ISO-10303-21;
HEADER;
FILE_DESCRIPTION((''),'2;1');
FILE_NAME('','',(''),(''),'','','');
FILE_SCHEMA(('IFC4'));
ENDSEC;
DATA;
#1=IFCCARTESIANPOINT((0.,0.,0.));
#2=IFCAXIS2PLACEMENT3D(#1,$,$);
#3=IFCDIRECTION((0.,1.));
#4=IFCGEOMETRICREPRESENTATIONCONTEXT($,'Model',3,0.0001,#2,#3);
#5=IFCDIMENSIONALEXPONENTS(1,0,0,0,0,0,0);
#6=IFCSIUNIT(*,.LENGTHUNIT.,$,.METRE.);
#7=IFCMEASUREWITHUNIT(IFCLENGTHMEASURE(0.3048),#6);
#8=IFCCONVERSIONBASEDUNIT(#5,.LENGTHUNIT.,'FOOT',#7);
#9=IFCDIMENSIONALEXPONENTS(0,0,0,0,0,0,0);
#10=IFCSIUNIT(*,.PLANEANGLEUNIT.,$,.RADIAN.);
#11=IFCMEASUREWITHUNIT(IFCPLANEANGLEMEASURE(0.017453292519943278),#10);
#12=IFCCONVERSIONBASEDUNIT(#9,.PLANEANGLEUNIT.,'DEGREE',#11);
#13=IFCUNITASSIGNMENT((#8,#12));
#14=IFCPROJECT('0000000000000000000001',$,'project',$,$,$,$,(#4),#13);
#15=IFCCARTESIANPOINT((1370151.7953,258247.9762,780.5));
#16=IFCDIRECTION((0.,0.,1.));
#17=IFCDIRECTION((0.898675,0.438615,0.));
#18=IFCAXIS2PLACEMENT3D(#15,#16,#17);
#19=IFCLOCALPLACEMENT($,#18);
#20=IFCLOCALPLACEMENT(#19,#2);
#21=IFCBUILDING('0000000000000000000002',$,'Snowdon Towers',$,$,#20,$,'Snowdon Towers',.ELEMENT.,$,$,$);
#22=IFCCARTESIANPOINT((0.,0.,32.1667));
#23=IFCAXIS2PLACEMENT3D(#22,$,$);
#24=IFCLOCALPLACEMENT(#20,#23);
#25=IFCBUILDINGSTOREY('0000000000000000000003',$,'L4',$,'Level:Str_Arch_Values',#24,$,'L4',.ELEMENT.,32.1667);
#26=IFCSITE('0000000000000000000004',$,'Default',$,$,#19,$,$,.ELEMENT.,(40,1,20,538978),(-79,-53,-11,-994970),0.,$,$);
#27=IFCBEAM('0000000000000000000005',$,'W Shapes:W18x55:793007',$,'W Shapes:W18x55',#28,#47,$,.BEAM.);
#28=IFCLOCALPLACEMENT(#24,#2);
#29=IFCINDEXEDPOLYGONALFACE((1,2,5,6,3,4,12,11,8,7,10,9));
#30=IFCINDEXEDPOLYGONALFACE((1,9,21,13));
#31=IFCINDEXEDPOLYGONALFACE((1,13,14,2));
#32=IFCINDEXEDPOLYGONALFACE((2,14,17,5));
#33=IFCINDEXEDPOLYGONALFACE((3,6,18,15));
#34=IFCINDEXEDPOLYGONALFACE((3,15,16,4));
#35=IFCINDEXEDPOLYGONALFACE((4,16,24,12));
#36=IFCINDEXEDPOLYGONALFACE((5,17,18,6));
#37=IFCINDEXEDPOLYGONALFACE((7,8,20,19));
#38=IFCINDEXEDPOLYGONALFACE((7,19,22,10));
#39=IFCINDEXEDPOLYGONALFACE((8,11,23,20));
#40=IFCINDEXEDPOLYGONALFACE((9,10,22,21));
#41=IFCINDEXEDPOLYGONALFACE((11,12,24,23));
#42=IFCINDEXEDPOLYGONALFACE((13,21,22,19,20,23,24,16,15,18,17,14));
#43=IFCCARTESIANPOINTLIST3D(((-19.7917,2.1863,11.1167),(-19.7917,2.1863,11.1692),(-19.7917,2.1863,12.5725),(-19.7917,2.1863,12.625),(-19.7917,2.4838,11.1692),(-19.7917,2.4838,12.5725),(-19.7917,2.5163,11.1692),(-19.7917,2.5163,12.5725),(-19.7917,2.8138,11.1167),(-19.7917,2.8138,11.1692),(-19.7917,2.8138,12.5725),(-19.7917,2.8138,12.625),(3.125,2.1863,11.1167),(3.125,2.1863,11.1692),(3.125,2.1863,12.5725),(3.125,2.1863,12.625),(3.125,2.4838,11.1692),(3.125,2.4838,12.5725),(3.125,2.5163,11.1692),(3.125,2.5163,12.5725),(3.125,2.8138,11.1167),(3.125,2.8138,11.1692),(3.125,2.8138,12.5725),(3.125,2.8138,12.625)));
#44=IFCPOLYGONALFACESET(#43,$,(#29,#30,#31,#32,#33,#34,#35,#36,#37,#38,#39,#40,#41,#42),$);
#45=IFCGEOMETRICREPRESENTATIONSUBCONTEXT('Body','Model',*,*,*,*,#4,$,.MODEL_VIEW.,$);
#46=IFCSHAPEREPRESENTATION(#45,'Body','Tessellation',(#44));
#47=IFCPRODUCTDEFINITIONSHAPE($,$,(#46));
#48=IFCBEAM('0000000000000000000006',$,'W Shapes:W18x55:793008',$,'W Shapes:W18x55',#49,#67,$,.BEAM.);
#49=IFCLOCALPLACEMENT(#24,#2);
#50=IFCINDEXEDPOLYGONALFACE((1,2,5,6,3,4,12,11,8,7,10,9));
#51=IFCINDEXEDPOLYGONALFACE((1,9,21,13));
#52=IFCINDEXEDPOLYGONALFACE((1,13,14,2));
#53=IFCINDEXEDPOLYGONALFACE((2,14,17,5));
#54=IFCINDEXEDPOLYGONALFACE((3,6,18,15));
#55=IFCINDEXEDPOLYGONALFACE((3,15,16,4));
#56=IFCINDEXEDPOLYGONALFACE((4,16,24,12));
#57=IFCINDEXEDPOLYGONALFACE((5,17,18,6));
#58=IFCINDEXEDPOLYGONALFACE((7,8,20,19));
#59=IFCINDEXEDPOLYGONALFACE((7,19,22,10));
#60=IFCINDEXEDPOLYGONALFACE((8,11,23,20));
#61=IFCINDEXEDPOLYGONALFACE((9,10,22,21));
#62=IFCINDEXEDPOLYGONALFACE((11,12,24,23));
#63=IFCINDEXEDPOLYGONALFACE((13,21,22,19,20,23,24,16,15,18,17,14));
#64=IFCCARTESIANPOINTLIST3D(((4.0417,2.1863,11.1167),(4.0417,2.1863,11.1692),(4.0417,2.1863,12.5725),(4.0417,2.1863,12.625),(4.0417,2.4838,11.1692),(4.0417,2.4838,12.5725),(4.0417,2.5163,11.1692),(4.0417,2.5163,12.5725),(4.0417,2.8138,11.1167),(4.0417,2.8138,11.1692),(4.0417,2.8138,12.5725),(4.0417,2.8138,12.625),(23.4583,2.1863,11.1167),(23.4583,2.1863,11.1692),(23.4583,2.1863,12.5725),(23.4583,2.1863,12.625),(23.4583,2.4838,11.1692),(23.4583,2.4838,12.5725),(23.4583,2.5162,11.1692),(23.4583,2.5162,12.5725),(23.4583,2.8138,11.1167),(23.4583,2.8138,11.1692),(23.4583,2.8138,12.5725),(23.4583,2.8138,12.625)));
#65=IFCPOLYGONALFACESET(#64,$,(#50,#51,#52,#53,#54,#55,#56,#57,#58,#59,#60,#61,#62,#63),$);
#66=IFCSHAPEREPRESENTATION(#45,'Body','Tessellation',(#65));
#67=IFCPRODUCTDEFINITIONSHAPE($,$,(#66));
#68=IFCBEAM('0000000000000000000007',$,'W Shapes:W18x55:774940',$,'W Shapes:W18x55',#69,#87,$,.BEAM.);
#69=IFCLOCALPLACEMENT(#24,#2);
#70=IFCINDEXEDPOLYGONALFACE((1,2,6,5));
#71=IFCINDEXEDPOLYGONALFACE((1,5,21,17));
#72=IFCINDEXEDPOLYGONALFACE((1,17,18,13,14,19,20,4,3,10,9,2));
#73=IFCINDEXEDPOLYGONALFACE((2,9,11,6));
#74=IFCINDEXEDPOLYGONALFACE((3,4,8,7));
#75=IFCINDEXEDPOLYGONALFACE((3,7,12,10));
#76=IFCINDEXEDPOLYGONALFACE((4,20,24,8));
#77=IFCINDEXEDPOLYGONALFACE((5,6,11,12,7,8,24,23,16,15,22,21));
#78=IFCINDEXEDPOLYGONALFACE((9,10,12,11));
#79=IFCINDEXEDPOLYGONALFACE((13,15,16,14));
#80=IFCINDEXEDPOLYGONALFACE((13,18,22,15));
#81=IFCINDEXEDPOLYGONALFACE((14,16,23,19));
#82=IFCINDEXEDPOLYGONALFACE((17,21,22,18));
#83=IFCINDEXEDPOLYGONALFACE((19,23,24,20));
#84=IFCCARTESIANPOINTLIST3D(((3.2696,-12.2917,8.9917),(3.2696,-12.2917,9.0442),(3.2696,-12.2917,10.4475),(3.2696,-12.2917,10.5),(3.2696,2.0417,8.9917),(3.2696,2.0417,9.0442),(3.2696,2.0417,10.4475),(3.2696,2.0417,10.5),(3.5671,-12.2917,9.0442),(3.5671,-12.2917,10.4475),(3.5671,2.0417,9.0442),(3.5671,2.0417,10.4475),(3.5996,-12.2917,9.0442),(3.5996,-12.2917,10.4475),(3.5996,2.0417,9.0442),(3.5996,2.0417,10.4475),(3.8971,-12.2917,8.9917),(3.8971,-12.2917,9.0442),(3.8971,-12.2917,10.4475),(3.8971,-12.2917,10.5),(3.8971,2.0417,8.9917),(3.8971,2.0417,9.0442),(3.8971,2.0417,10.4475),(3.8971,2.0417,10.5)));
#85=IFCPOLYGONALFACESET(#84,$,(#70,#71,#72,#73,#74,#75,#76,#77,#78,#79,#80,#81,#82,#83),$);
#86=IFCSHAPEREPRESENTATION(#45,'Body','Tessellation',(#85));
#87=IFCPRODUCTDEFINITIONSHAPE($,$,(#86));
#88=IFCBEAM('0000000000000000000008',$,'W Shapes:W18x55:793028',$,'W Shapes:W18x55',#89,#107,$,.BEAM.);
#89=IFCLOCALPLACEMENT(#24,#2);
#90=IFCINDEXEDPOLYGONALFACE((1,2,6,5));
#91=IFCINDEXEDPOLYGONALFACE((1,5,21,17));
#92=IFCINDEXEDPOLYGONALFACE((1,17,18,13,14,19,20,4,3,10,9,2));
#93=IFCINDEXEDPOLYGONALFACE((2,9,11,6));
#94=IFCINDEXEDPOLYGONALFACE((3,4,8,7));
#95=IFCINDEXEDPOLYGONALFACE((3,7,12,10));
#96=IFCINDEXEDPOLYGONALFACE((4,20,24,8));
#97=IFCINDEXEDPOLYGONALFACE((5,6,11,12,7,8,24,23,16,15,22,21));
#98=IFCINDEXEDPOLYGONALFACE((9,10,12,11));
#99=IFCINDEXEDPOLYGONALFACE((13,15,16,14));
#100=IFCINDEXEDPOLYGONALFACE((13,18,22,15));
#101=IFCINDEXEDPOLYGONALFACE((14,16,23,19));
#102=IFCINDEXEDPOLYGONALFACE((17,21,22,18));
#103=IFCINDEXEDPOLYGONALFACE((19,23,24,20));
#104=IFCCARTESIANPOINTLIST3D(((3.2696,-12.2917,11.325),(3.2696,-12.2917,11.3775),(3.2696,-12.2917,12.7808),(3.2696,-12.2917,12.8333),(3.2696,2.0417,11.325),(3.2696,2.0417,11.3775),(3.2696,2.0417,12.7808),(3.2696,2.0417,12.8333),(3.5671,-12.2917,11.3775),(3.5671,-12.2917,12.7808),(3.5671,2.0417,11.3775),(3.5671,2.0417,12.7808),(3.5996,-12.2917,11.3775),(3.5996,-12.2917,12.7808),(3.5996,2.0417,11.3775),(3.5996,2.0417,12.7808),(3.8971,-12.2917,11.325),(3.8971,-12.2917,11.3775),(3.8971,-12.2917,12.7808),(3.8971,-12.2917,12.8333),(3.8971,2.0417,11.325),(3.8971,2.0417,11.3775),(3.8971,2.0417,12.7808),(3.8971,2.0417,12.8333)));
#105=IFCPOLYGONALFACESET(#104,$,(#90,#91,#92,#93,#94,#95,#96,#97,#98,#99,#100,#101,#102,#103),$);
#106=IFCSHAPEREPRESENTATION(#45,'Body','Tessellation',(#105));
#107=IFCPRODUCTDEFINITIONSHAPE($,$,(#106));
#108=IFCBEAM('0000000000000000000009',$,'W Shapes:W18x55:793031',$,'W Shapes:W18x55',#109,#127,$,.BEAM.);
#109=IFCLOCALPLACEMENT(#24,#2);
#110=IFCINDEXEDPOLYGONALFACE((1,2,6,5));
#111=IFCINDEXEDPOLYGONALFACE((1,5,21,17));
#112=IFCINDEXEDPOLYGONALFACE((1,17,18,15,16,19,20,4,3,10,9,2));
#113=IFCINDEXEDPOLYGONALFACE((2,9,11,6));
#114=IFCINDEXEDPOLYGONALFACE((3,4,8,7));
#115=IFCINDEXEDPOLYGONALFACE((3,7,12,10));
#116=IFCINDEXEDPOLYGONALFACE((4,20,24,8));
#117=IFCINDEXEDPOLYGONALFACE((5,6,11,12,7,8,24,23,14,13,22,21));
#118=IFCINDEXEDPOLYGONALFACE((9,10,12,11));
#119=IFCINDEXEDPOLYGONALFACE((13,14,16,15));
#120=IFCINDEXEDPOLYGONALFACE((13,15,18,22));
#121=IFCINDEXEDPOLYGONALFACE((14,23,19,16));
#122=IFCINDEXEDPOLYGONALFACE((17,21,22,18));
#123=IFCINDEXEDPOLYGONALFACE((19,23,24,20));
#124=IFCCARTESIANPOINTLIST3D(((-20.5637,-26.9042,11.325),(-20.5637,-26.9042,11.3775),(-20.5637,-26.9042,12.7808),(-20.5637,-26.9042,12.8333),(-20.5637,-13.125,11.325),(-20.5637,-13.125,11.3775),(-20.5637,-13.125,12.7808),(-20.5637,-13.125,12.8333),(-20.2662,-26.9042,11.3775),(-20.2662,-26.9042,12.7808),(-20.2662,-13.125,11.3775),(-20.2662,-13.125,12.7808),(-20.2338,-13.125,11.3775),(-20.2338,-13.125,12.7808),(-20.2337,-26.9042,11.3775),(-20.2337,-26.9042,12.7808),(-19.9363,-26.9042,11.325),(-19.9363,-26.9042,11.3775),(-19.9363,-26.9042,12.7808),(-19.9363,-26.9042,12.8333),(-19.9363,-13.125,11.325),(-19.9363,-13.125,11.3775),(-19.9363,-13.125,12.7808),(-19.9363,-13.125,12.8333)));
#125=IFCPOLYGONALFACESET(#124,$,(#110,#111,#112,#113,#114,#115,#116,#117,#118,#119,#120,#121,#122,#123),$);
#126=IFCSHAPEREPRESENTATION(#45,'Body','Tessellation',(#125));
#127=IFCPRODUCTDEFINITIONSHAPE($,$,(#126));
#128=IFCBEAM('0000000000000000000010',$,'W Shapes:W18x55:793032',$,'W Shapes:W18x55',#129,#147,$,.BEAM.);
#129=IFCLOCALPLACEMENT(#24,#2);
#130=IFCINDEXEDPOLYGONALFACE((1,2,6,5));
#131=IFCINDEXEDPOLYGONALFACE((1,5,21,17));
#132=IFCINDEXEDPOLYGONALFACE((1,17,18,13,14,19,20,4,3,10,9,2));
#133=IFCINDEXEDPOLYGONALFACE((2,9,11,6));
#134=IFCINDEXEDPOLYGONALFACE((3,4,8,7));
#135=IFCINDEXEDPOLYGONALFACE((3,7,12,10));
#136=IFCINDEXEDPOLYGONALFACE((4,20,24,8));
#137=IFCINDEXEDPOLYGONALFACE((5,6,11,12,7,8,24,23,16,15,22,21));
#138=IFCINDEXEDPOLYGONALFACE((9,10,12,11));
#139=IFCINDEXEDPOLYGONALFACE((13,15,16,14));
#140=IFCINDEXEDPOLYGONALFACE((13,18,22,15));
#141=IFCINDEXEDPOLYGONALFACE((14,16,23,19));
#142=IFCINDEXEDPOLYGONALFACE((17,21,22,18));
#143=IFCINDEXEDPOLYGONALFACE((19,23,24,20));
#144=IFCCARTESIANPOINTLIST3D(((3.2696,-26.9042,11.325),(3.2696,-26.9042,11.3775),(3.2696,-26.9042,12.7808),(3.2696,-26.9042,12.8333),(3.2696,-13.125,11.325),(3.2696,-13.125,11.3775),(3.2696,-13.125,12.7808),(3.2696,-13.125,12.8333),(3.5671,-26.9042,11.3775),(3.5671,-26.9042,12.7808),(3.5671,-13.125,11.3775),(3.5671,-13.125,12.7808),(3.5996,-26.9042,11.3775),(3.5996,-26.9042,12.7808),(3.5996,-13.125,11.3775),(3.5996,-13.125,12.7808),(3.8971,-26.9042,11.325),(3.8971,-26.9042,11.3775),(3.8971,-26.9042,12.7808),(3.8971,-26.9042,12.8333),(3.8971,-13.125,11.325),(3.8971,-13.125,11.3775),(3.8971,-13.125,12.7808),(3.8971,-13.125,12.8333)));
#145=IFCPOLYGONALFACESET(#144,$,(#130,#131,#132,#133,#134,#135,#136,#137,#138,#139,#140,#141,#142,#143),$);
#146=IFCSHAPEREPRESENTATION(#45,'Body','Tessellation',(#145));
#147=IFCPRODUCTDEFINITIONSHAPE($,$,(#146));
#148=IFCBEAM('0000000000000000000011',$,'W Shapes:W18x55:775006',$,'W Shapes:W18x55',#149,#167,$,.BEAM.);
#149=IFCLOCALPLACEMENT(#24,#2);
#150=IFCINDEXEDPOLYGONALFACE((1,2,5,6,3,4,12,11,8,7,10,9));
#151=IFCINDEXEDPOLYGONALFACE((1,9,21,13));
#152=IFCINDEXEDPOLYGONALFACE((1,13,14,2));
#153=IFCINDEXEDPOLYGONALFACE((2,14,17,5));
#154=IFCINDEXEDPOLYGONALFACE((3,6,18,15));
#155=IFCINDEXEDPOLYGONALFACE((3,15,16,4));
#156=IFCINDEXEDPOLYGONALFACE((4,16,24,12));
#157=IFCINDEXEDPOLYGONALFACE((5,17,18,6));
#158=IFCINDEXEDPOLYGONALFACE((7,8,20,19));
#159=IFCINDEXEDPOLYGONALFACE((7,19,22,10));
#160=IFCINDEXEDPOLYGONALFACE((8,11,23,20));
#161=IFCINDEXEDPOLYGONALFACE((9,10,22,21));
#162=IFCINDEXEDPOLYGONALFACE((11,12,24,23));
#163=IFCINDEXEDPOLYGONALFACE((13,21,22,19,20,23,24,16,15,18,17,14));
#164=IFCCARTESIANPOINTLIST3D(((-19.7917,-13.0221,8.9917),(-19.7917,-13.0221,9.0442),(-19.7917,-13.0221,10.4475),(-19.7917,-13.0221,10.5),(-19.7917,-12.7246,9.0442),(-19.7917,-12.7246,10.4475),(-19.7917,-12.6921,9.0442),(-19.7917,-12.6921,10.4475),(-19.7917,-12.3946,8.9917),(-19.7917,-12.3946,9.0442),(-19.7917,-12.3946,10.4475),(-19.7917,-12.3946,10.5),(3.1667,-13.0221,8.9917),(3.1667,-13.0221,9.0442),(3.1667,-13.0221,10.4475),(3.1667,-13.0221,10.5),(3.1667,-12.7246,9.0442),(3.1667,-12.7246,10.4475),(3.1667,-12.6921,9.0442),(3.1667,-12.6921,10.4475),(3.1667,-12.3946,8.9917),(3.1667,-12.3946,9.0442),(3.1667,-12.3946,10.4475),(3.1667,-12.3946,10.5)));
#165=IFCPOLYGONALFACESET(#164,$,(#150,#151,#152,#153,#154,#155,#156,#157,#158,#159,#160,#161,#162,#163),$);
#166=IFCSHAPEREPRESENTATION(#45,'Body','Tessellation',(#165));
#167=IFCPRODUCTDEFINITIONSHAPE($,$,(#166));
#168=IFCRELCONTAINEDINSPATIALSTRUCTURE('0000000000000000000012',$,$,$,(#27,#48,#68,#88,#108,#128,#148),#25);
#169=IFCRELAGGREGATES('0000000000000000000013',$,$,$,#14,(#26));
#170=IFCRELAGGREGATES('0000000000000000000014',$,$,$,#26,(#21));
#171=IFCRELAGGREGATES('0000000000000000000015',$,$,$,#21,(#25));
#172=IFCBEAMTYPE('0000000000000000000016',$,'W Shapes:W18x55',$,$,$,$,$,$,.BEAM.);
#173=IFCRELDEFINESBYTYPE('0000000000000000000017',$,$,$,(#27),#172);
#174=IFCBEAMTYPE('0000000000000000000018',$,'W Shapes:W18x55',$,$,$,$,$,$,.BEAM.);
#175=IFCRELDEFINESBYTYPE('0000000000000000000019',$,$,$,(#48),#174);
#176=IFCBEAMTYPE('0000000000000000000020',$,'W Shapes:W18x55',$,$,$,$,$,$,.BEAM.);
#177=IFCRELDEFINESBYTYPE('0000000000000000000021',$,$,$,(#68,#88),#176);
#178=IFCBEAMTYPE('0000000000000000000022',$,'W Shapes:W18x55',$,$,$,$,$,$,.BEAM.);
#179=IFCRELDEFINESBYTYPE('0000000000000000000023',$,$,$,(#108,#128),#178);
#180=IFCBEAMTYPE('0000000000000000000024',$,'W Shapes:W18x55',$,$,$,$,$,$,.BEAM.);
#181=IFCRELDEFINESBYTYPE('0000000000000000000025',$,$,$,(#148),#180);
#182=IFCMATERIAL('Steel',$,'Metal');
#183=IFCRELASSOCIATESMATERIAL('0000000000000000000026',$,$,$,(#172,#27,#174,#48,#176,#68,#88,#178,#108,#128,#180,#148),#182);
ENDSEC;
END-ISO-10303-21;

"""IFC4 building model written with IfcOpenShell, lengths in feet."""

from ifc_helpers import new_model, entity, si_unit, converted_unit, direction, frame, origin, place, context, subcontext, project, spatial, indexed_curve, outline, extrude, source, transform, mapped, material, type_object, type_shapes, element, save


model = new_model("IFC4")

# Units and contexts
model_context = context("Model", 3, precision=0.0001, world=origin(), true_north=direction((0.0, 1.0)))
body_context = subcontext(model_context, "Body", "Model", "MODEL_VIEW")
ifc_project = project(units=[converted_unit("LENGTHUNIT", "FOOT", entity("IfcLengthMeasure", 0.3048), si_unit("LENGTHUNIT", "METRE"), dimensions=[1, 0, 0, 0, 0, 0, 0]), converted_unit("PLANEANGLEUNIT", "DEGREE", entity("IfcPlaneAngleMeasure", 0.017453292519943278), si_unit("PLANEANGLEUNIT", "RADIAN"), dimensions=[0, 0, 0, 0, 0, 0, 0])], contexts=[model_context])

# Site, building, storey
site_placement = place(None, frame((1370151.7953, 258247.9762, 780.5), z_axis=(0.0, 0.0, 1.0), x_axis=(0.898675, 0.438615, 0.0)))
site = spatial("IfcSite", under=ifc_project, at=site_placement, Name="Default", CompositionType="ELEMENT", RefLatitude=(40, 1, 20, 538978), RefLongitude=(-79, -53, -11, -994970), RefElevation=0.0)
building_placement = place(site_placement, origin())
building = spatial("IfcBuilding", under=site, at=building_placement, Name="Snowdon Towers", LongName="Snowdon Towers", CompositionType="ELEMENT")
storey_placement = place(building_placement, frame((0.0, 0.0, 32.1667)))
storey = spatial("IfcBuildingStorey", under=building, at=storey_placement, Name="L4", ObjectType="Level:Str_Arch_Values", LongName="L4", CompositionType="ELEMENT", Elevation=32.1667)

# Beams
ifc_material_1 = material(Name="Steel", Category="Metal")
beam_type_1 = type_object("IfcBeamType", Name="W Shapes:W18x55", PredefinedType="BEAM", material=ifc_material_1)
shared_shape_1 = source(origin(), body_context, "Body", "SweptSolid", [
    extrude(outline(indexed_curve([(-0.3138, -0.7017), (-0.3138, -0.7542), (0.3138, -0.7542), (0.3138, -0.7017), (0.0162, -0.7017), (0.0162, 0.7017), (0.3138, 0.7017), (0.3138, 0.7542), (-0.3137, 0.7542), (-0.3137, 0.7017), (-0.0163, 0.7017), (-0.0163, -0.7017), (-0.3138, -0.7017)], self_intersect=False)), frame((-11.5417, 0.0, 0.0), z_axis=(-1.0, 0.0, 0.0), x_axis=(0.0, -1.0, 0.0)), (0.0, 0.0, -1.0), 22.9167),
])
type_shapes(beam_type_1, [shared_shape_1])
beam_1_placement = place(storey_placement, frame((-8.25, 2.5, 11.8708)))
element("IfcBeam", 1, at=beam_1_placement, inside=storey, type_object=beam_type_1, material=ifc_material_1, Name="W Shapes:W18x55:793007", ObjectType="W Shapes:W18x55", PredefinedType="BEAM", context=body_context, shape_type="MappedRepresentation", body=[
    mapped(shared_shape_1, transform((0.0, 0.0, 0.0), scale=1.0)),
])
beam_type_2 = type_object("IfcBeamType", Name="W Shapes:W18x55", PredefinedType="BEAM", material=ifc_material_1)
shared_shape_2 = source(origin(), body_context, "Body", "SweptSolid", [
    extrude(outline(indexed_curve([(-0.3138, -0.7017), (-0.3138, -0.7542), (0.3138, -0.7542), (0.3138, -0.7017), (0.0162, -0.7017), (0.0162, 0.7017), (0.3138, 0.7017), (0.3138, 0.7542), (-0.3137, 0.7542), (-0.3137, 0.7017), (-0.0163, 0.7017), (-0.0163, -0.7017), (-0.3138, -0.7017)], self_intersect=False)), frame((-9.7917, 0.0, 0.0), z_axis=(-1.0, 0.0, 0.0), x_axis=(0.0, -1.0, 0.0)), (0.0, 0.0, -1.0), 19.4167),
])
type_shapes(beam_type_2, [shared_shape_2])
beam_2_placement = place(storey_placement, frame((13.8333, 2.5, 11.8708)))
element("IfcBeam", 2, at=beam_2_placement, inside=storey, type_object=beam_type_2, material=ifc_material_1, Name="W Shapes:W18x55:793008", ObjectType="W Shapes:W18x55", PredefinedType="BEAM", context=body_context, shape_type="MappedRepresentation", body=[
    mapped(shared_shape_2, transform((0.0, 0.0, 0.0), scale=1.0)),
])
beam_type_3 = type_object("IfcBeamType", Name="W Shapes:W18x55", PredefinedType="BEAM", material=ifc_material_1)
shared_shape_3 = source(origin(), body_context, "Body", "SweptSolid", [
    extrude(outline(indexed_curve([(-0.3138, -0.7017), (-0.3138, -0.7542), (0.3138, -0.7542), (0.3138, -0.7017), (0.0162, -0.7017), (0.0162, 0.7017), (0.3138, 0.7017), (0.3138, 0.7542), (-0.3137, 0.7542), (-0.3137, 0.7017), (-0.0163, 0.7017), (-0.0163, -0.7017), (-0.3138, -0.7017)], self_intersect=False)), frame((-7.1458, 0.0, 0.0), z_axis=(-1.0, 0.0, 0.0), x_axis=(0.0, -1.0, 0.0)), (0.0, 0.0, -1.0), 14.3333),
])
type_shapes(beam_type_3, [shared_shape_3])
for number, where, z_axis, x_axis, name in (
    (3, (3.5833, -5.1042, 9.7458), (0.0, 0.0, 1.0), (0.0, -1.0, 0.0), "W Shapes:W18x55:774940"),
    (4, (3.5833, -5.1042, 12.0792), (0.0, 0.0, 1.0), (0.0, -1.0, 0.0), "W Shapes:W18x55:793028"),
):
    element("IfcBeam", number, at=place(storey_placement, frame(where, z_axis=z_axis, x_axis=x_axis)), inside=storey, type_object=beam_type_3, material=ifc_material_1, Name=name, ObjectType="W Shapes:W18x55", PredefinedType="BEAM", context=body_context, shape_type="MappedRepresentation", body=[
        mapped(shared_shape_3, transform((0.0, 0.0, 0.0), scale=1.0)),
    ])
beam_type_4 = type_object("IfcBeamType", Name="W Shapes:W18x55", PredefinedType="BEAM", material=ifc_material_1)
shared_shape_4 = source(origin(), body_context, "Body", "SweptSolid", [
    extrude(outline(indexed_curve([(-0.3138, -0.7017), (-0.3138, -0.7542), (0.3138, -0.7542), (0.3138, -0.7017), (0.0162, -0.7017), (0.0162, 0.7017), (0.3138, 0.7017), (0.3138, 0.7542), (-0.3137, 0.7542), (-0.3137, 0.7017), (-0.0163, 0.7017), (-0.0163, -0.7017), (-0.3138, -0.7017)], self_intersect=False)), frame((-7.2292, 0.0, 0.0), z_axis=(-1.0, 0.0, 0.0), x_axis=(0.0, -1.0, 0.0)), (0.0, 0.0, -1.0), 13.7792),
])
type_shapes(beam_type_4, [shared_shape_4])
for number, where, z_axis, x_axis, name in (
    (5, (-20.25, -20.3542, 12.0792), (0.0, 0.0, 1.0), (0.0, -1.0, 0.0), "W Shapes:W18x55:793031"),
    (6, (3.5833, -20.3542, 12.0792), (0.0, 0.0, 1.0), (0.0, -1.0, 0.0), "W Shapes:W18x55:793032"),
):
    element("IfcBeam", number, at=place(storey_placement, frame(where, z_axis=z_axis, x_axis=x_axis)), inside=storey, type_object=beam_type_4, material=ifc_material_1, Name=name, ObjectType="W Shapes:W18x55", PredefinedType="BEAM", context=body_context, shape_type="MappedRepresentation", body=[
        mapped(shared_shape_4, transform((0.0, 0.0, 0.0), scale=1.0)),
    ])

# Beam
beam_type_5 = type_object("IfcBeamType", Name="W Shapes:W18x55", PredefinedType="BEAM", material=ifc_material_1)
shared_shape_5 = source(origin(), body_context, "Body", "SweptSolid", [
    extrude(outline(indexed_curve([(-0.3138, -0.7017), (-0.3138, -0.7542), (0.3138, -0.7542), (0.3138, -0.7017), (0.0162, -0.7017), (0.0162, 0.7017), (0.3138, 0.7017), (0.3138, 0.7542), (-0.3137, 0.7542), (-0.3137, 0.7017), (-0.0163, 0.7017), (-0.0163, -0.7017), (-0.3138, -0.7017)], self_intersect=False)), frame((-11.4583, 0.0, 0.0), z_axis=(-1.0, 0.0, 0.0), x_axis=(0.0, -1.0, 0.0)), (0.0, 0.0, -1.0), 22.9583),
])
type_shapes(beam_type_5, [shared_shape_5])
beam_3_placement = place(storey_placement, frame((-8.3333, -12.7083, 9.7458)))
element("IfcBeam", 7, at=beam_3_placement, inside=storey, type_object=beam_type_5, material=ifc_material_1, Name="W Shapes:W18x55:775006", ObjectType="W Shapes:W18x55", PredefinedType="BEAM", context=body_context, shape_type="MappedRepresentation", body=[
    mapped(shared_shape_5, transform((0.0, 0.0, 0.0), scale=1.0)),
])

save(model, "model.ifc")
